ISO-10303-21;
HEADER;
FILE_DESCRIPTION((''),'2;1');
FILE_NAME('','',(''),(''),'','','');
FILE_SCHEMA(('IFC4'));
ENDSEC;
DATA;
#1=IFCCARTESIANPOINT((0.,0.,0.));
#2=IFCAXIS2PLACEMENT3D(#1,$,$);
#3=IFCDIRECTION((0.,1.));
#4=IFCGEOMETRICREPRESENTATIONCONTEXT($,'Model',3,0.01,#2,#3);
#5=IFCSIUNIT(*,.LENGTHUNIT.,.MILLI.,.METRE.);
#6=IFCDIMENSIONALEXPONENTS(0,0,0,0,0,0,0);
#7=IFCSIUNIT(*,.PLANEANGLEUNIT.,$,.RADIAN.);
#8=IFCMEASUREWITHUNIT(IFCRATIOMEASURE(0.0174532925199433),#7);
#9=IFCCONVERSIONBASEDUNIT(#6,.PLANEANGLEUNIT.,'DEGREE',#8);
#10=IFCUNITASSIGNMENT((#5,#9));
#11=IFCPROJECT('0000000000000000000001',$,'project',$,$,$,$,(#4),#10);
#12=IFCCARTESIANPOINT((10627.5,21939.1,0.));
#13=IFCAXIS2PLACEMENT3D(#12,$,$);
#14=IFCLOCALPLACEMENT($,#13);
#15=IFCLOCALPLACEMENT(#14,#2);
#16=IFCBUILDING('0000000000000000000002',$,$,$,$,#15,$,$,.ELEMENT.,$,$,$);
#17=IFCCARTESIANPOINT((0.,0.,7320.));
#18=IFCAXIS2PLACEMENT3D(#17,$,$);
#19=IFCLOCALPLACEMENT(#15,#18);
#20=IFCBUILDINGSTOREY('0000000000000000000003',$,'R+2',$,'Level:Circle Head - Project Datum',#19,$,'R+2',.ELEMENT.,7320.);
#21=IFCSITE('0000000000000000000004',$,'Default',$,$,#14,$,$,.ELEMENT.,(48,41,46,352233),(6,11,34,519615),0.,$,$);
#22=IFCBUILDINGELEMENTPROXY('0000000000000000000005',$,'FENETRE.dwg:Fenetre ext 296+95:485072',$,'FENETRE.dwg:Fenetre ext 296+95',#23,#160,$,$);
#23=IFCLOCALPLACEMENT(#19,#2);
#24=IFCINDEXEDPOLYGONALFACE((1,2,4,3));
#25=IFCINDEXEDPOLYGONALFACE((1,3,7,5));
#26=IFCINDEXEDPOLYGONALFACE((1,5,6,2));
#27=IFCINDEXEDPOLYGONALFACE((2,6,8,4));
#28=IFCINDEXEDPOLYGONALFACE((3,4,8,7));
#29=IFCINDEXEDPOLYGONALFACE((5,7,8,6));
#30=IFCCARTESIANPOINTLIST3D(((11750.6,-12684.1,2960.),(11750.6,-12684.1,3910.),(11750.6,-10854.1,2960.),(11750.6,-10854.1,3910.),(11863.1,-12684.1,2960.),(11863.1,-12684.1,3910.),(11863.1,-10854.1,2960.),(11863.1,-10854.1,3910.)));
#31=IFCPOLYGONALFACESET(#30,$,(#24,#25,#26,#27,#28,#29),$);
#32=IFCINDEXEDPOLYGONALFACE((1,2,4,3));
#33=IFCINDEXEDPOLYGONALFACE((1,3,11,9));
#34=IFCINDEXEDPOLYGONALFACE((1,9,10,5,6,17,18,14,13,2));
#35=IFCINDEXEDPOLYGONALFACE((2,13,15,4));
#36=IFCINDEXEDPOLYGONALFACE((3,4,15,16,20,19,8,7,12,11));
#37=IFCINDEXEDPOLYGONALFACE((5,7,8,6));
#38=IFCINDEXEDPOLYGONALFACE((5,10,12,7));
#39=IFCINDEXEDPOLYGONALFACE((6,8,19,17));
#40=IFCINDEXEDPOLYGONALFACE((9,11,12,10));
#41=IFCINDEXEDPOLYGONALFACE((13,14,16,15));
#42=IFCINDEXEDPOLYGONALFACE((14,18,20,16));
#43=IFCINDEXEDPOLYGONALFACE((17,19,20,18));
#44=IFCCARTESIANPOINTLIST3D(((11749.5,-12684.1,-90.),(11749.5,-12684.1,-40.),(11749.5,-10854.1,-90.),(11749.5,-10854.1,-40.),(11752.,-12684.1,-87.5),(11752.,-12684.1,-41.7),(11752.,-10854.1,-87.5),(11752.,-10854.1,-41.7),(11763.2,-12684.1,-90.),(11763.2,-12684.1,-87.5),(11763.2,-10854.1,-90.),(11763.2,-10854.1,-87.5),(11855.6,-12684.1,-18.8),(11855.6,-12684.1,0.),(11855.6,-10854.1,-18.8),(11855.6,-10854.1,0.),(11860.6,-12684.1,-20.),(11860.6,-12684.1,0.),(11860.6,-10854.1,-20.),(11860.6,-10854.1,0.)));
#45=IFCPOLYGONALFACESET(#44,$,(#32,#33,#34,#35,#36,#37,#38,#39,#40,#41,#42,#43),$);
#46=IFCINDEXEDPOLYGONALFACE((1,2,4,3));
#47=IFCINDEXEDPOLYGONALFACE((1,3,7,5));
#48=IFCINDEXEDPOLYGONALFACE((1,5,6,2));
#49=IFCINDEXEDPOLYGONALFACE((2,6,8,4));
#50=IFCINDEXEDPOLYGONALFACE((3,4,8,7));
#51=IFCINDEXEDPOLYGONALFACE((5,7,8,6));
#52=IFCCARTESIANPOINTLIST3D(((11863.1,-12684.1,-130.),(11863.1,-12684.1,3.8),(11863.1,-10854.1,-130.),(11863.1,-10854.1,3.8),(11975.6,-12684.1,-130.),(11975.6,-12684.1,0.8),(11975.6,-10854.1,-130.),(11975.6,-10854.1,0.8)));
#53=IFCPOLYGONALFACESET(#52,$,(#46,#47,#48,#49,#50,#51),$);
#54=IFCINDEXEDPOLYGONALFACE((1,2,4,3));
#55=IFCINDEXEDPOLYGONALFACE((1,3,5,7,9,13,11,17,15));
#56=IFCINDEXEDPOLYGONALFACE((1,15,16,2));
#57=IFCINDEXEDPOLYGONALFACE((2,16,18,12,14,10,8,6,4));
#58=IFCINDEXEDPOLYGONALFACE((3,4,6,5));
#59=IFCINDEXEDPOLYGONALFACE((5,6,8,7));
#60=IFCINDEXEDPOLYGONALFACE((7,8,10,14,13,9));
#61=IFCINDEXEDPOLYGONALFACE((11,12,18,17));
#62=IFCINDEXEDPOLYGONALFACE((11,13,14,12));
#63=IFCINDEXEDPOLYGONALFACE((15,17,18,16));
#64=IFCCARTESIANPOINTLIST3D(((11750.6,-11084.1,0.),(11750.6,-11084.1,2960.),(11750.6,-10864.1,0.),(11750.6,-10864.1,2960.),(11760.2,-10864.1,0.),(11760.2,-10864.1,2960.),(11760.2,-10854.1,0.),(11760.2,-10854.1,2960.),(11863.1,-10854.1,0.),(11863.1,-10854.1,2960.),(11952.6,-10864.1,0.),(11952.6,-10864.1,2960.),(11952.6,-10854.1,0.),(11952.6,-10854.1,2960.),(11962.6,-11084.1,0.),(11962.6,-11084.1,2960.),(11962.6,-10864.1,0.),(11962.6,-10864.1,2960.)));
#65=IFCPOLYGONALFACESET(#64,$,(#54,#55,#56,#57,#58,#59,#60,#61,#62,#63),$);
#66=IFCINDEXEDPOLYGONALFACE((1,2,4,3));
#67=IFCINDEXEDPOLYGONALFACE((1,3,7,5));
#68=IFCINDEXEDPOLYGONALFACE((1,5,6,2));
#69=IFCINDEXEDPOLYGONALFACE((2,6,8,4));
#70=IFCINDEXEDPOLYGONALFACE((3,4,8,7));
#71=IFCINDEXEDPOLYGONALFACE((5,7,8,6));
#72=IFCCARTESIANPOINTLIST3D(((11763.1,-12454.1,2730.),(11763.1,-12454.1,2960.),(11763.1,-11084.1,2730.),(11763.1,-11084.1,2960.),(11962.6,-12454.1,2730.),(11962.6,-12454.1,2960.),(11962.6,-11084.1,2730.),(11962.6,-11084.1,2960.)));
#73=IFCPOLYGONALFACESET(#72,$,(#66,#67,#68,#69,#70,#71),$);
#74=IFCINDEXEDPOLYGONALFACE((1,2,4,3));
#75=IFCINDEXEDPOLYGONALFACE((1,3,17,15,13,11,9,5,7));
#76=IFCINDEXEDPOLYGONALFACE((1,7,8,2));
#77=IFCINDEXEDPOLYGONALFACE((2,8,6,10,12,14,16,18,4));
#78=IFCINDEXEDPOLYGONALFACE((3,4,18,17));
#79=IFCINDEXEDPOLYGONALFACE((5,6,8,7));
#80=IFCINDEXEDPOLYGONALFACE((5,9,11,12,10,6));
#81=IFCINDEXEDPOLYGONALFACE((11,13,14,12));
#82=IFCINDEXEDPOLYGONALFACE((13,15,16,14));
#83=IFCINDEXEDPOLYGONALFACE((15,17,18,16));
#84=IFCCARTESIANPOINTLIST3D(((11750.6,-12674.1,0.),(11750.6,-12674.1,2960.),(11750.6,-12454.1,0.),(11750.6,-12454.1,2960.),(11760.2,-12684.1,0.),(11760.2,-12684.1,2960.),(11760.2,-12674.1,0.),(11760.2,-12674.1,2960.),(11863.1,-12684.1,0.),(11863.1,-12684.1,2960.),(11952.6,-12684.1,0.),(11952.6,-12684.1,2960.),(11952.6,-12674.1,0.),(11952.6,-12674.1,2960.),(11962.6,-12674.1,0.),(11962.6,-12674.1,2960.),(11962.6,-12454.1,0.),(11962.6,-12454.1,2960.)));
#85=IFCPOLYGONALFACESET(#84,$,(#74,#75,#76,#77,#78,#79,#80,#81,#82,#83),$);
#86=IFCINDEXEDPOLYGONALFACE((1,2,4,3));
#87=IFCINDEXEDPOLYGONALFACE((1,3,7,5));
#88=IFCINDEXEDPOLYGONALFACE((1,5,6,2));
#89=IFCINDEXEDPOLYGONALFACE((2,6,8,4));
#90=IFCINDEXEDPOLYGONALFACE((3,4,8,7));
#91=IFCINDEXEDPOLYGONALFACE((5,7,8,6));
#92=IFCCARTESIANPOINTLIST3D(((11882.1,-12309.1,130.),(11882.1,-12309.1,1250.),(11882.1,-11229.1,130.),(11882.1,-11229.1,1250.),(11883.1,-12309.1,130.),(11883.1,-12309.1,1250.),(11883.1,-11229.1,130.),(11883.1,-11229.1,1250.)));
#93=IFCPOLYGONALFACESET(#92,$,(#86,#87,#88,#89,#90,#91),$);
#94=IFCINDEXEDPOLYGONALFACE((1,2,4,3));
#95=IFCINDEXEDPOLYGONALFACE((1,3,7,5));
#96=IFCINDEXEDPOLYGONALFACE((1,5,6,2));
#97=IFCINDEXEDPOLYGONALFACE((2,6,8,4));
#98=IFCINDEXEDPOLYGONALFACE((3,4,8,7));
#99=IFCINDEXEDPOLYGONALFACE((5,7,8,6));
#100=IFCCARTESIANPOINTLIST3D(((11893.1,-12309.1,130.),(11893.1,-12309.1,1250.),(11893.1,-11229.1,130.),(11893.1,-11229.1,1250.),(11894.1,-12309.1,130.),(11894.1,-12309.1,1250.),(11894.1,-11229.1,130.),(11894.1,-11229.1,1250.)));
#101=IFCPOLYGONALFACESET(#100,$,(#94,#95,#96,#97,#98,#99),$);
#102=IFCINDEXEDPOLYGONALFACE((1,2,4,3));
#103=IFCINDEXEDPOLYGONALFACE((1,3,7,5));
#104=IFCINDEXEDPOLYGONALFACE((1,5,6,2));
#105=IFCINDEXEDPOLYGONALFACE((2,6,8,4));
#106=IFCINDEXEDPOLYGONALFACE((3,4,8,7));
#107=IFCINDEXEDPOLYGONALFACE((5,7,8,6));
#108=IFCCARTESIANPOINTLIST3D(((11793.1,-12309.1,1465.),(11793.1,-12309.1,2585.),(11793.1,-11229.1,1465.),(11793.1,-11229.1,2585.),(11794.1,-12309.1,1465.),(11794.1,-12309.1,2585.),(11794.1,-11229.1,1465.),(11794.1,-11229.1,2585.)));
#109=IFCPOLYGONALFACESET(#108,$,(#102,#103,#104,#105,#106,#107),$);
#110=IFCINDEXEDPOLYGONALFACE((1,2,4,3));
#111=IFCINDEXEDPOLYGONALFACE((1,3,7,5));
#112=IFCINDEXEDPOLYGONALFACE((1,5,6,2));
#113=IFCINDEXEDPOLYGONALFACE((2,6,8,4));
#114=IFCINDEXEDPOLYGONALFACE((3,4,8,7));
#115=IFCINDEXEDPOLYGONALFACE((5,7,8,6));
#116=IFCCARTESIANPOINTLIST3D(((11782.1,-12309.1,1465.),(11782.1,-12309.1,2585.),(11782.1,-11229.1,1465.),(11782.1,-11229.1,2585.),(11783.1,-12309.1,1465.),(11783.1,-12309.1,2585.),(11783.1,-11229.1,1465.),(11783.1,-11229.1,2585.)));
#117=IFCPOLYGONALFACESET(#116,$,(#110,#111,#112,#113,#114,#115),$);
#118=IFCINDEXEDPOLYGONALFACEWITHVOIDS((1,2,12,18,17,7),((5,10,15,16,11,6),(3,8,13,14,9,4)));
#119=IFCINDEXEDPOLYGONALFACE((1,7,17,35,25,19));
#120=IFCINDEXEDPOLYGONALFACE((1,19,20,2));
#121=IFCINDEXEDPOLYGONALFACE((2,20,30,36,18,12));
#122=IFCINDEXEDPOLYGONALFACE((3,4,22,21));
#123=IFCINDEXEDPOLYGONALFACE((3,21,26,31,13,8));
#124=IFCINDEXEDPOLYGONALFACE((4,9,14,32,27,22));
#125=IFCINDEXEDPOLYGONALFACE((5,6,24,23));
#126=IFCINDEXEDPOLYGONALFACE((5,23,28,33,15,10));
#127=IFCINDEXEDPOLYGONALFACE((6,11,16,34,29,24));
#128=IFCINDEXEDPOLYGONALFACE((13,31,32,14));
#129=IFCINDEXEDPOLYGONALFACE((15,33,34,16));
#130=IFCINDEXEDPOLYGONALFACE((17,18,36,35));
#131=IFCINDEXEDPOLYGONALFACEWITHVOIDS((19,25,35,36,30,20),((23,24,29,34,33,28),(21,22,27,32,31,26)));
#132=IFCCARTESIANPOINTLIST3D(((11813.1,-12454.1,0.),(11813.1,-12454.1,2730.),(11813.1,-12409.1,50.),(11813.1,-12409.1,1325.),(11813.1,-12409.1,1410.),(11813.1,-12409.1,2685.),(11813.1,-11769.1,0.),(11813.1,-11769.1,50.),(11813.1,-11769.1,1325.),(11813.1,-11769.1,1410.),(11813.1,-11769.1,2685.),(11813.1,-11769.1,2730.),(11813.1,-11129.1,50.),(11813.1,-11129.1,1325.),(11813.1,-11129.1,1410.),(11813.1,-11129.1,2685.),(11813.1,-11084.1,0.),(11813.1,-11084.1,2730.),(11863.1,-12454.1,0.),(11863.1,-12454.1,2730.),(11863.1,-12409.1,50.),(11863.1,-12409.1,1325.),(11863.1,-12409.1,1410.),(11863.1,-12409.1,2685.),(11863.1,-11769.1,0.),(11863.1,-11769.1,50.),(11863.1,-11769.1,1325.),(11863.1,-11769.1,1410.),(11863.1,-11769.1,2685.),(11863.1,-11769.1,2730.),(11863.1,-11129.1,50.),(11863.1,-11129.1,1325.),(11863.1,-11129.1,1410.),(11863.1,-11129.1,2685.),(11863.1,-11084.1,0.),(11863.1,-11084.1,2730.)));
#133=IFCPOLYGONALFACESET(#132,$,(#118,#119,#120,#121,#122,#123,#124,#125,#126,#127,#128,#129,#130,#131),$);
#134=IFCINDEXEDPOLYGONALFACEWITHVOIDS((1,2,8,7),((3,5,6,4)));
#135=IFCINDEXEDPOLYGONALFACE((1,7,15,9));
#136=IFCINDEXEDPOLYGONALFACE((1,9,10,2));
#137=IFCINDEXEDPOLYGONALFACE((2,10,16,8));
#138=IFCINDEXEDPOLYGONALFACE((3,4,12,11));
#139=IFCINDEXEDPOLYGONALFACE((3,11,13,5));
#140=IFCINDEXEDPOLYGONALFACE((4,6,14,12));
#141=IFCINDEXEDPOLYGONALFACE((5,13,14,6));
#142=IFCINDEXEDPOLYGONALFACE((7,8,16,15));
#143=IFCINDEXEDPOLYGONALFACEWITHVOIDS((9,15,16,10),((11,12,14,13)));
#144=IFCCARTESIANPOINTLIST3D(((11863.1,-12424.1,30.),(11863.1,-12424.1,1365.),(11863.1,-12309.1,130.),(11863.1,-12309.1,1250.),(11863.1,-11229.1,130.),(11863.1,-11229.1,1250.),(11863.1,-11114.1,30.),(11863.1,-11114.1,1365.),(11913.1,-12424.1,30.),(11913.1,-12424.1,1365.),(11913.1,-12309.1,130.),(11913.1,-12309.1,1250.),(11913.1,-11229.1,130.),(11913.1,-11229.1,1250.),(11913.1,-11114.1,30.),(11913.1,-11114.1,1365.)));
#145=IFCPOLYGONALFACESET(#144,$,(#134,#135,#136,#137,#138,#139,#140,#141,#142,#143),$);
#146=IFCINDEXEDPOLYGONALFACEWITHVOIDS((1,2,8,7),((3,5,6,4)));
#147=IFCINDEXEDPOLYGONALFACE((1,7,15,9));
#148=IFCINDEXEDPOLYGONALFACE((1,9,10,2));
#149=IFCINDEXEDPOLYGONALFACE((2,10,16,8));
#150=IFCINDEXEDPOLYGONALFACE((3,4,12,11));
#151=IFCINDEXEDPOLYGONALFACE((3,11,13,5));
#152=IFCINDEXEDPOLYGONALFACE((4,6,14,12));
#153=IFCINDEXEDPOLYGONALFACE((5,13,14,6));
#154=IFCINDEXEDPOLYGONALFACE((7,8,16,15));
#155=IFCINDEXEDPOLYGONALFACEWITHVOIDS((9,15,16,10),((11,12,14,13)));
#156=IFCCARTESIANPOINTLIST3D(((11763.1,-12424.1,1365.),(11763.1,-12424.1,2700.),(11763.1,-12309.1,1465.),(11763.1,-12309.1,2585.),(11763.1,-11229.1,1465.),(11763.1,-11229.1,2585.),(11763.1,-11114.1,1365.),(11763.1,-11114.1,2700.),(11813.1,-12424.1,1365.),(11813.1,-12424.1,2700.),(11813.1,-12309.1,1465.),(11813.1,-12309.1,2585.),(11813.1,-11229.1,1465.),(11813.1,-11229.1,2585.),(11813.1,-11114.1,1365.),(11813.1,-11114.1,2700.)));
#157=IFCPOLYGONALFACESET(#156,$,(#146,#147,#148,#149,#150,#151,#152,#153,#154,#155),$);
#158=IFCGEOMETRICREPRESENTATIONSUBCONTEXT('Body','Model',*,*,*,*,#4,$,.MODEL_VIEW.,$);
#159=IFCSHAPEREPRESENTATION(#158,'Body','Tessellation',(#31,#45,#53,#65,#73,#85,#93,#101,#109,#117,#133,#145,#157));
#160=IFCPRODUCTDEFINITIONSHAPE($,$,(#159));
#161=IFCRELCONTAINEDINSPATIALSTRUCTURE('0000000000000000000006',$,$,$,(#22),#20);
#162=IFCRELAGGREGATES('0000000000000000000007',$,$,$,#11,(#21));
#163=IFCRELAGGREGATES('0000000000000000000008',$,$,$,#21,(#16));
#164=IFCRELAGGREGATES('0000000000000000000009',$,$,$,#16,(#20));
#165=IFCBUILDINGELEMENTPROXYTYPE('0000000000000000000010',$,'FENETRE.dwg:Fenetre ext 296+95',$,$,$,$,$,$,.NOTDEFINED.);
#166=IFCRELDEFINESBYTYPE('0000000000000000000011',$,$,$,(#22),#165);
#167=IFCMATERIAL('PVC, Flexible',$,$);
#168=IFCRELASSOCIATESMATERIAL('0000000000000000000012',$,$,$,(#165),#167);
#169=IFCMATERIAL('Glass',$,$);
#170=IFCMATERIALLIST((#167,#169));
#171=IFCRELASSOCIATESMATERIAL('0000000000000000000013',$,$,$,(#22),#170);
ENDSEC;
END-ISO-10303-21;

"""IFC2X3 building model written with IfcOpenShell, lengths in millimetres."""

from ifc_helpers import new_model, entity, si_unit, converted_unit, direction, frame, frame_2d, origin, origin_2d_with_axis, place, context, subcontext, project, spatial, polyline, rectangle, outline, extrude, source, transform, mapped, material, material_list, type_object, type_shapes, element, save


model = new_model("IFC2X3")

# Units and contexts
model_context = context("Model", 3, precision=0.01, world=origin(), true_north=direction((0.0, 1.0)))
body_context = subcontext(model_context, "Body", "Model", "MODEL_VIEW")
ifc_project = project(units=[si_unit("LENGTHUNIT", "METRE", prefix="MILLI"), converted_unit("PLANEANGLEUNIT", "DEGREE", entity("IfcRatioMeasure", 0.0174532925199433), si_unit("PLANEANGLEUNIT", "RADIAN"), dimensions=[0, 0, 0, 0, 0, 0, 0])], contexts=[model_context])

# Site, building, storey
site_placement = place(None, frame((10627.5, 21939.1, 0.0)))
site = spatial("IfcSite", under=ifc_project, at=site_placement, Name="Default", CompositionType="ELEMENT", RefLatitude=(48, 41, 46, 352233), RefLongitude=(6, 11, 34, 519615), RefElevation=0.0)
building_placement = place(site_placement, origin())
building = spatial("IfcBuilding", under=site, at=building_placement, CompositionType="ELEMENT")
storey_placement = place(building_placement, frame((0.0, 0.0, 7320.0)))
storey = spatial("IfcBuildingStorey", under=building, at=storey_placement, Name="R+2", ObjectType="Level:Circle Head - Project Datum", LongName="R+2", CompositionType="ELEMENT", Elevation=7320.0)

# Building element proxy
ifc_material_1 = material(Name="PVC, Flexible")
ifc_material_2 = material(Name="Glass")
building_element_proxy_type_1 = type_object("IfcBuildingElementProxyType", Name="FENETRE.dwg:Fenetre ext 296+95", PredefinedType="NOTDEFINED", material=ifc_material_1)
shared_shape_1 = source(origin(), body_context, "Body", "SweptSolid", [
    extrude(rectangle(XDim=1830.0, YDim=112.5, at=origin_2d_with_axis()), frame((-10.4, 56.3, 2960.0), z_axis=(0.0, 0.0, 1.0), x_axis=(-1.0, 0.0, 0.0)), (0.0, 0.0, 1.0), 950.0),
    extrude(outline(polyline([(-68.6, -14.4), (-72.5, -34.0), (-67.6, -35.0), (-63.9, -16.6), (44.3, -16.6), (54.1, 32.5), (40.6, 35.2), (40.1, 32.7), (51.2, 30.5), (42.2, -14.4), (-68.6, -14.4)])), frame((-925.4, 66.9, -47.5), z_axis=(-1.0, 0.0, 0.0), x_axis=(0.0, 0.980599, -0.196027)), (0.0, 0.0, -1.0), 1830.0),
    extrude(outline(polyline([(-64.7, -56.3), (66.2, -56.3), (66.2, 56.3), (-67.7, 56.3), (-64.7, -56.3)])), frame((-925.4, -56.3, -63.8), z_axis=(1.0, 0.0, 0.0), x_axis=(0.0, 0.0, -1.0)), (0.0, 0.0, 1.0), 1830.0),
    extrude(outline(polyline([(-55.6, 97.0), (-55.6, -5.9), (-55.6, -95.4), (-45.6, -95.4), (-45.6, -105.4), (174.4, -105.4), (174.4, 106.6), (-45.6, 106.6), (-45.6, 97.0), (-55.6, 97.0)])), frame((849.0, 5.9, 0.0), z_axis=(0.0, 0.0, -1.0), x_axis=(-1.0, 0.0, 0.0)), (0.0, 0.0, -1.0), 2960.0),
    extrude(rectangle(XDim=199.5, YDim=1370.0, at=origin_2d_with_axis()), frame((-10.4, 0.3, 2730.0), z_axis=(0.0, 0.0, 1.0), x_axis=(0.0, 1.0, 0.0)), (0.0, 0.0, 1.0), 230.0),
    extrude(outline(polyline([(-97.0, -55.6), (5.9, -55.6), (95.4, -55.6), (95.4, -45.6), (105.4, -45.6), (105.4, 174.4), (-106.6, 174.4), (-106.6, -45.6), (-97.0, -45.6), (-97.0, -55.6)])), frame((-869.9, 5.9, 0.0), z_axis=(0.0, 0.0, 1.0), x_axis=(0.0, -1.0, 0.0)), (0.0, 0.0, 1.0), 2960.0),
    extrude(rectangle(XDim=1.0, YDim=1080.0, at=origin_2d_with_axis()), frame((-10.4, -19.5, 130.0), z_axis=(0.0, 0.0, 1.0), x_axis=(0.0, 1.0, 0.0)), (0.0, 0.0, 1.0), 1120.0),
    extrude(rectangle(XDim=1.0, YDim=1080.0, at=frame_2d((0.0, 0.0), x_axis=(1.0, 0.0))), frame((-10.4, -30.5, 130.0), z_axis=(0.0, 0.0, 1.0), x_axis=(0.0, 1.0, 0.0)), (0.0, 0.0, 1.0), 1120.0),
    extrude(rectangle(XDim=1.0, YDim=1080.0, at=frame_2d((0.0, 0.0), x_axis=(1.0, 0.0))), frame((-10.4, 69.5, 1465.0), z_axis=(0.0, 0.0, 1.0), x_axis=(0.0, 1.0, 0.0)), (0.0, 0.0, 1.0), 1120.0),
    extrude(rectangle(XDim=1.0, YDim=1080.0, at=frame_2d((0.0, 0.0), x_axis=(1.0, 0.0))), frame((-10.4, 80.5, 1465.0), z_axis=(0.0, 0.0, 1.0), x_axis=(0.0, 1.0, 0.0)), (0.0, 0.0, 1.0), 1120.0),
    extrude(outline(polyline([(-685.0, -1365.0), (0.0, -1365.0), (685.0, -1365.0), (685.0, 1365.0), (0.0, 1365.0), (-685.0, 1365.0), (-685.0, -1365.0)]), holes=[polyline([(-640.0, -1320.0), (-640.0, -45.0), (0.0, -45.0), (640.0, -45.0), (640.0, -1320.0), (0.0, -1320.0), (-640.0, -1320.0)]), polyline([(-640.0, 40.0), (-640.0, 1315.0), (0.0, 1315.0), (640.0, 1315.0), (640.0, 40.0), (0.0, 40.0), (-640.0, 40.0)])]), frame((-10.4, 0.0, 1365.0), z_axis=(0.0, 1.0, 0.0), x_axis=(1.0, 0.0, 0.0)), (0.0, 0.0, 1.0), 50.0),
    extrude(outline(polyline([(-655.0, -667.5), (655.0, -667.5), (655.0, 667.5), (-655.0, 667.5), (-655.0, -667.5)]), holes=[polyline([(-540.0, 552.5), (540.0, 552.5), (540.0, -567.5), (-540.0, -567.5), (-540.0, 552.5)])]), frame((-10.4, -50.0, 697.5), z_axis=(0.0, 1.0, 0.0), x_axis=(-1.0, 0.0, 0.0)), (0.0, 0.0, 1.0), 50.0),
    extrude(outline(polyline([(-655.0, -667.5), (655.0, -667.5), (655.0, 667.5), (-655.0, 667.5), (-655.0, -667.5)]), holes=[polyline([(-540.0, 552.5), (540.0, 552.5), (540.0, -567.5), (-540.0, -567.5), (-540.0, 552.5)])]), frame((-10.4, 50.0, 2032.5), z_axis=(0.0, 1.0, 0.0), x_axis=(-1.0, 0.0, 0.0)), (0.0, 0.0, 1.0), 50.0),
])
type_shapes(building_element_proxy_type_1, [shared_shape_1])
ifc_material_list_1 = material_list([ifc_material_1, ifc_material_2])
proxy_1_placement = place(storey_placement, frame((11863.1, -11758.7, 0.0), z_axis=(0.0, 0.0, 1.0), x_axis=(0.0, 1.0, 0.0)))
element("IfcBuildingElementProxy", 1, at=proxy_1_placement, inside=storey, type_object=building_element_proxy_type_1, material=ifc_material_list_1, Name="FENETRE.dwg:Fenetre ext 296+95:485072", ObjectType="FENETRE.dwg:Fenetre ext 296+95", context=body_context, shape_type="MappedRepresentation", body=[
    mapped(shared_shape_1, transform((0.0, 0.0, 0.0), scale=1.0)),
])

save(model, "model.ifc")
